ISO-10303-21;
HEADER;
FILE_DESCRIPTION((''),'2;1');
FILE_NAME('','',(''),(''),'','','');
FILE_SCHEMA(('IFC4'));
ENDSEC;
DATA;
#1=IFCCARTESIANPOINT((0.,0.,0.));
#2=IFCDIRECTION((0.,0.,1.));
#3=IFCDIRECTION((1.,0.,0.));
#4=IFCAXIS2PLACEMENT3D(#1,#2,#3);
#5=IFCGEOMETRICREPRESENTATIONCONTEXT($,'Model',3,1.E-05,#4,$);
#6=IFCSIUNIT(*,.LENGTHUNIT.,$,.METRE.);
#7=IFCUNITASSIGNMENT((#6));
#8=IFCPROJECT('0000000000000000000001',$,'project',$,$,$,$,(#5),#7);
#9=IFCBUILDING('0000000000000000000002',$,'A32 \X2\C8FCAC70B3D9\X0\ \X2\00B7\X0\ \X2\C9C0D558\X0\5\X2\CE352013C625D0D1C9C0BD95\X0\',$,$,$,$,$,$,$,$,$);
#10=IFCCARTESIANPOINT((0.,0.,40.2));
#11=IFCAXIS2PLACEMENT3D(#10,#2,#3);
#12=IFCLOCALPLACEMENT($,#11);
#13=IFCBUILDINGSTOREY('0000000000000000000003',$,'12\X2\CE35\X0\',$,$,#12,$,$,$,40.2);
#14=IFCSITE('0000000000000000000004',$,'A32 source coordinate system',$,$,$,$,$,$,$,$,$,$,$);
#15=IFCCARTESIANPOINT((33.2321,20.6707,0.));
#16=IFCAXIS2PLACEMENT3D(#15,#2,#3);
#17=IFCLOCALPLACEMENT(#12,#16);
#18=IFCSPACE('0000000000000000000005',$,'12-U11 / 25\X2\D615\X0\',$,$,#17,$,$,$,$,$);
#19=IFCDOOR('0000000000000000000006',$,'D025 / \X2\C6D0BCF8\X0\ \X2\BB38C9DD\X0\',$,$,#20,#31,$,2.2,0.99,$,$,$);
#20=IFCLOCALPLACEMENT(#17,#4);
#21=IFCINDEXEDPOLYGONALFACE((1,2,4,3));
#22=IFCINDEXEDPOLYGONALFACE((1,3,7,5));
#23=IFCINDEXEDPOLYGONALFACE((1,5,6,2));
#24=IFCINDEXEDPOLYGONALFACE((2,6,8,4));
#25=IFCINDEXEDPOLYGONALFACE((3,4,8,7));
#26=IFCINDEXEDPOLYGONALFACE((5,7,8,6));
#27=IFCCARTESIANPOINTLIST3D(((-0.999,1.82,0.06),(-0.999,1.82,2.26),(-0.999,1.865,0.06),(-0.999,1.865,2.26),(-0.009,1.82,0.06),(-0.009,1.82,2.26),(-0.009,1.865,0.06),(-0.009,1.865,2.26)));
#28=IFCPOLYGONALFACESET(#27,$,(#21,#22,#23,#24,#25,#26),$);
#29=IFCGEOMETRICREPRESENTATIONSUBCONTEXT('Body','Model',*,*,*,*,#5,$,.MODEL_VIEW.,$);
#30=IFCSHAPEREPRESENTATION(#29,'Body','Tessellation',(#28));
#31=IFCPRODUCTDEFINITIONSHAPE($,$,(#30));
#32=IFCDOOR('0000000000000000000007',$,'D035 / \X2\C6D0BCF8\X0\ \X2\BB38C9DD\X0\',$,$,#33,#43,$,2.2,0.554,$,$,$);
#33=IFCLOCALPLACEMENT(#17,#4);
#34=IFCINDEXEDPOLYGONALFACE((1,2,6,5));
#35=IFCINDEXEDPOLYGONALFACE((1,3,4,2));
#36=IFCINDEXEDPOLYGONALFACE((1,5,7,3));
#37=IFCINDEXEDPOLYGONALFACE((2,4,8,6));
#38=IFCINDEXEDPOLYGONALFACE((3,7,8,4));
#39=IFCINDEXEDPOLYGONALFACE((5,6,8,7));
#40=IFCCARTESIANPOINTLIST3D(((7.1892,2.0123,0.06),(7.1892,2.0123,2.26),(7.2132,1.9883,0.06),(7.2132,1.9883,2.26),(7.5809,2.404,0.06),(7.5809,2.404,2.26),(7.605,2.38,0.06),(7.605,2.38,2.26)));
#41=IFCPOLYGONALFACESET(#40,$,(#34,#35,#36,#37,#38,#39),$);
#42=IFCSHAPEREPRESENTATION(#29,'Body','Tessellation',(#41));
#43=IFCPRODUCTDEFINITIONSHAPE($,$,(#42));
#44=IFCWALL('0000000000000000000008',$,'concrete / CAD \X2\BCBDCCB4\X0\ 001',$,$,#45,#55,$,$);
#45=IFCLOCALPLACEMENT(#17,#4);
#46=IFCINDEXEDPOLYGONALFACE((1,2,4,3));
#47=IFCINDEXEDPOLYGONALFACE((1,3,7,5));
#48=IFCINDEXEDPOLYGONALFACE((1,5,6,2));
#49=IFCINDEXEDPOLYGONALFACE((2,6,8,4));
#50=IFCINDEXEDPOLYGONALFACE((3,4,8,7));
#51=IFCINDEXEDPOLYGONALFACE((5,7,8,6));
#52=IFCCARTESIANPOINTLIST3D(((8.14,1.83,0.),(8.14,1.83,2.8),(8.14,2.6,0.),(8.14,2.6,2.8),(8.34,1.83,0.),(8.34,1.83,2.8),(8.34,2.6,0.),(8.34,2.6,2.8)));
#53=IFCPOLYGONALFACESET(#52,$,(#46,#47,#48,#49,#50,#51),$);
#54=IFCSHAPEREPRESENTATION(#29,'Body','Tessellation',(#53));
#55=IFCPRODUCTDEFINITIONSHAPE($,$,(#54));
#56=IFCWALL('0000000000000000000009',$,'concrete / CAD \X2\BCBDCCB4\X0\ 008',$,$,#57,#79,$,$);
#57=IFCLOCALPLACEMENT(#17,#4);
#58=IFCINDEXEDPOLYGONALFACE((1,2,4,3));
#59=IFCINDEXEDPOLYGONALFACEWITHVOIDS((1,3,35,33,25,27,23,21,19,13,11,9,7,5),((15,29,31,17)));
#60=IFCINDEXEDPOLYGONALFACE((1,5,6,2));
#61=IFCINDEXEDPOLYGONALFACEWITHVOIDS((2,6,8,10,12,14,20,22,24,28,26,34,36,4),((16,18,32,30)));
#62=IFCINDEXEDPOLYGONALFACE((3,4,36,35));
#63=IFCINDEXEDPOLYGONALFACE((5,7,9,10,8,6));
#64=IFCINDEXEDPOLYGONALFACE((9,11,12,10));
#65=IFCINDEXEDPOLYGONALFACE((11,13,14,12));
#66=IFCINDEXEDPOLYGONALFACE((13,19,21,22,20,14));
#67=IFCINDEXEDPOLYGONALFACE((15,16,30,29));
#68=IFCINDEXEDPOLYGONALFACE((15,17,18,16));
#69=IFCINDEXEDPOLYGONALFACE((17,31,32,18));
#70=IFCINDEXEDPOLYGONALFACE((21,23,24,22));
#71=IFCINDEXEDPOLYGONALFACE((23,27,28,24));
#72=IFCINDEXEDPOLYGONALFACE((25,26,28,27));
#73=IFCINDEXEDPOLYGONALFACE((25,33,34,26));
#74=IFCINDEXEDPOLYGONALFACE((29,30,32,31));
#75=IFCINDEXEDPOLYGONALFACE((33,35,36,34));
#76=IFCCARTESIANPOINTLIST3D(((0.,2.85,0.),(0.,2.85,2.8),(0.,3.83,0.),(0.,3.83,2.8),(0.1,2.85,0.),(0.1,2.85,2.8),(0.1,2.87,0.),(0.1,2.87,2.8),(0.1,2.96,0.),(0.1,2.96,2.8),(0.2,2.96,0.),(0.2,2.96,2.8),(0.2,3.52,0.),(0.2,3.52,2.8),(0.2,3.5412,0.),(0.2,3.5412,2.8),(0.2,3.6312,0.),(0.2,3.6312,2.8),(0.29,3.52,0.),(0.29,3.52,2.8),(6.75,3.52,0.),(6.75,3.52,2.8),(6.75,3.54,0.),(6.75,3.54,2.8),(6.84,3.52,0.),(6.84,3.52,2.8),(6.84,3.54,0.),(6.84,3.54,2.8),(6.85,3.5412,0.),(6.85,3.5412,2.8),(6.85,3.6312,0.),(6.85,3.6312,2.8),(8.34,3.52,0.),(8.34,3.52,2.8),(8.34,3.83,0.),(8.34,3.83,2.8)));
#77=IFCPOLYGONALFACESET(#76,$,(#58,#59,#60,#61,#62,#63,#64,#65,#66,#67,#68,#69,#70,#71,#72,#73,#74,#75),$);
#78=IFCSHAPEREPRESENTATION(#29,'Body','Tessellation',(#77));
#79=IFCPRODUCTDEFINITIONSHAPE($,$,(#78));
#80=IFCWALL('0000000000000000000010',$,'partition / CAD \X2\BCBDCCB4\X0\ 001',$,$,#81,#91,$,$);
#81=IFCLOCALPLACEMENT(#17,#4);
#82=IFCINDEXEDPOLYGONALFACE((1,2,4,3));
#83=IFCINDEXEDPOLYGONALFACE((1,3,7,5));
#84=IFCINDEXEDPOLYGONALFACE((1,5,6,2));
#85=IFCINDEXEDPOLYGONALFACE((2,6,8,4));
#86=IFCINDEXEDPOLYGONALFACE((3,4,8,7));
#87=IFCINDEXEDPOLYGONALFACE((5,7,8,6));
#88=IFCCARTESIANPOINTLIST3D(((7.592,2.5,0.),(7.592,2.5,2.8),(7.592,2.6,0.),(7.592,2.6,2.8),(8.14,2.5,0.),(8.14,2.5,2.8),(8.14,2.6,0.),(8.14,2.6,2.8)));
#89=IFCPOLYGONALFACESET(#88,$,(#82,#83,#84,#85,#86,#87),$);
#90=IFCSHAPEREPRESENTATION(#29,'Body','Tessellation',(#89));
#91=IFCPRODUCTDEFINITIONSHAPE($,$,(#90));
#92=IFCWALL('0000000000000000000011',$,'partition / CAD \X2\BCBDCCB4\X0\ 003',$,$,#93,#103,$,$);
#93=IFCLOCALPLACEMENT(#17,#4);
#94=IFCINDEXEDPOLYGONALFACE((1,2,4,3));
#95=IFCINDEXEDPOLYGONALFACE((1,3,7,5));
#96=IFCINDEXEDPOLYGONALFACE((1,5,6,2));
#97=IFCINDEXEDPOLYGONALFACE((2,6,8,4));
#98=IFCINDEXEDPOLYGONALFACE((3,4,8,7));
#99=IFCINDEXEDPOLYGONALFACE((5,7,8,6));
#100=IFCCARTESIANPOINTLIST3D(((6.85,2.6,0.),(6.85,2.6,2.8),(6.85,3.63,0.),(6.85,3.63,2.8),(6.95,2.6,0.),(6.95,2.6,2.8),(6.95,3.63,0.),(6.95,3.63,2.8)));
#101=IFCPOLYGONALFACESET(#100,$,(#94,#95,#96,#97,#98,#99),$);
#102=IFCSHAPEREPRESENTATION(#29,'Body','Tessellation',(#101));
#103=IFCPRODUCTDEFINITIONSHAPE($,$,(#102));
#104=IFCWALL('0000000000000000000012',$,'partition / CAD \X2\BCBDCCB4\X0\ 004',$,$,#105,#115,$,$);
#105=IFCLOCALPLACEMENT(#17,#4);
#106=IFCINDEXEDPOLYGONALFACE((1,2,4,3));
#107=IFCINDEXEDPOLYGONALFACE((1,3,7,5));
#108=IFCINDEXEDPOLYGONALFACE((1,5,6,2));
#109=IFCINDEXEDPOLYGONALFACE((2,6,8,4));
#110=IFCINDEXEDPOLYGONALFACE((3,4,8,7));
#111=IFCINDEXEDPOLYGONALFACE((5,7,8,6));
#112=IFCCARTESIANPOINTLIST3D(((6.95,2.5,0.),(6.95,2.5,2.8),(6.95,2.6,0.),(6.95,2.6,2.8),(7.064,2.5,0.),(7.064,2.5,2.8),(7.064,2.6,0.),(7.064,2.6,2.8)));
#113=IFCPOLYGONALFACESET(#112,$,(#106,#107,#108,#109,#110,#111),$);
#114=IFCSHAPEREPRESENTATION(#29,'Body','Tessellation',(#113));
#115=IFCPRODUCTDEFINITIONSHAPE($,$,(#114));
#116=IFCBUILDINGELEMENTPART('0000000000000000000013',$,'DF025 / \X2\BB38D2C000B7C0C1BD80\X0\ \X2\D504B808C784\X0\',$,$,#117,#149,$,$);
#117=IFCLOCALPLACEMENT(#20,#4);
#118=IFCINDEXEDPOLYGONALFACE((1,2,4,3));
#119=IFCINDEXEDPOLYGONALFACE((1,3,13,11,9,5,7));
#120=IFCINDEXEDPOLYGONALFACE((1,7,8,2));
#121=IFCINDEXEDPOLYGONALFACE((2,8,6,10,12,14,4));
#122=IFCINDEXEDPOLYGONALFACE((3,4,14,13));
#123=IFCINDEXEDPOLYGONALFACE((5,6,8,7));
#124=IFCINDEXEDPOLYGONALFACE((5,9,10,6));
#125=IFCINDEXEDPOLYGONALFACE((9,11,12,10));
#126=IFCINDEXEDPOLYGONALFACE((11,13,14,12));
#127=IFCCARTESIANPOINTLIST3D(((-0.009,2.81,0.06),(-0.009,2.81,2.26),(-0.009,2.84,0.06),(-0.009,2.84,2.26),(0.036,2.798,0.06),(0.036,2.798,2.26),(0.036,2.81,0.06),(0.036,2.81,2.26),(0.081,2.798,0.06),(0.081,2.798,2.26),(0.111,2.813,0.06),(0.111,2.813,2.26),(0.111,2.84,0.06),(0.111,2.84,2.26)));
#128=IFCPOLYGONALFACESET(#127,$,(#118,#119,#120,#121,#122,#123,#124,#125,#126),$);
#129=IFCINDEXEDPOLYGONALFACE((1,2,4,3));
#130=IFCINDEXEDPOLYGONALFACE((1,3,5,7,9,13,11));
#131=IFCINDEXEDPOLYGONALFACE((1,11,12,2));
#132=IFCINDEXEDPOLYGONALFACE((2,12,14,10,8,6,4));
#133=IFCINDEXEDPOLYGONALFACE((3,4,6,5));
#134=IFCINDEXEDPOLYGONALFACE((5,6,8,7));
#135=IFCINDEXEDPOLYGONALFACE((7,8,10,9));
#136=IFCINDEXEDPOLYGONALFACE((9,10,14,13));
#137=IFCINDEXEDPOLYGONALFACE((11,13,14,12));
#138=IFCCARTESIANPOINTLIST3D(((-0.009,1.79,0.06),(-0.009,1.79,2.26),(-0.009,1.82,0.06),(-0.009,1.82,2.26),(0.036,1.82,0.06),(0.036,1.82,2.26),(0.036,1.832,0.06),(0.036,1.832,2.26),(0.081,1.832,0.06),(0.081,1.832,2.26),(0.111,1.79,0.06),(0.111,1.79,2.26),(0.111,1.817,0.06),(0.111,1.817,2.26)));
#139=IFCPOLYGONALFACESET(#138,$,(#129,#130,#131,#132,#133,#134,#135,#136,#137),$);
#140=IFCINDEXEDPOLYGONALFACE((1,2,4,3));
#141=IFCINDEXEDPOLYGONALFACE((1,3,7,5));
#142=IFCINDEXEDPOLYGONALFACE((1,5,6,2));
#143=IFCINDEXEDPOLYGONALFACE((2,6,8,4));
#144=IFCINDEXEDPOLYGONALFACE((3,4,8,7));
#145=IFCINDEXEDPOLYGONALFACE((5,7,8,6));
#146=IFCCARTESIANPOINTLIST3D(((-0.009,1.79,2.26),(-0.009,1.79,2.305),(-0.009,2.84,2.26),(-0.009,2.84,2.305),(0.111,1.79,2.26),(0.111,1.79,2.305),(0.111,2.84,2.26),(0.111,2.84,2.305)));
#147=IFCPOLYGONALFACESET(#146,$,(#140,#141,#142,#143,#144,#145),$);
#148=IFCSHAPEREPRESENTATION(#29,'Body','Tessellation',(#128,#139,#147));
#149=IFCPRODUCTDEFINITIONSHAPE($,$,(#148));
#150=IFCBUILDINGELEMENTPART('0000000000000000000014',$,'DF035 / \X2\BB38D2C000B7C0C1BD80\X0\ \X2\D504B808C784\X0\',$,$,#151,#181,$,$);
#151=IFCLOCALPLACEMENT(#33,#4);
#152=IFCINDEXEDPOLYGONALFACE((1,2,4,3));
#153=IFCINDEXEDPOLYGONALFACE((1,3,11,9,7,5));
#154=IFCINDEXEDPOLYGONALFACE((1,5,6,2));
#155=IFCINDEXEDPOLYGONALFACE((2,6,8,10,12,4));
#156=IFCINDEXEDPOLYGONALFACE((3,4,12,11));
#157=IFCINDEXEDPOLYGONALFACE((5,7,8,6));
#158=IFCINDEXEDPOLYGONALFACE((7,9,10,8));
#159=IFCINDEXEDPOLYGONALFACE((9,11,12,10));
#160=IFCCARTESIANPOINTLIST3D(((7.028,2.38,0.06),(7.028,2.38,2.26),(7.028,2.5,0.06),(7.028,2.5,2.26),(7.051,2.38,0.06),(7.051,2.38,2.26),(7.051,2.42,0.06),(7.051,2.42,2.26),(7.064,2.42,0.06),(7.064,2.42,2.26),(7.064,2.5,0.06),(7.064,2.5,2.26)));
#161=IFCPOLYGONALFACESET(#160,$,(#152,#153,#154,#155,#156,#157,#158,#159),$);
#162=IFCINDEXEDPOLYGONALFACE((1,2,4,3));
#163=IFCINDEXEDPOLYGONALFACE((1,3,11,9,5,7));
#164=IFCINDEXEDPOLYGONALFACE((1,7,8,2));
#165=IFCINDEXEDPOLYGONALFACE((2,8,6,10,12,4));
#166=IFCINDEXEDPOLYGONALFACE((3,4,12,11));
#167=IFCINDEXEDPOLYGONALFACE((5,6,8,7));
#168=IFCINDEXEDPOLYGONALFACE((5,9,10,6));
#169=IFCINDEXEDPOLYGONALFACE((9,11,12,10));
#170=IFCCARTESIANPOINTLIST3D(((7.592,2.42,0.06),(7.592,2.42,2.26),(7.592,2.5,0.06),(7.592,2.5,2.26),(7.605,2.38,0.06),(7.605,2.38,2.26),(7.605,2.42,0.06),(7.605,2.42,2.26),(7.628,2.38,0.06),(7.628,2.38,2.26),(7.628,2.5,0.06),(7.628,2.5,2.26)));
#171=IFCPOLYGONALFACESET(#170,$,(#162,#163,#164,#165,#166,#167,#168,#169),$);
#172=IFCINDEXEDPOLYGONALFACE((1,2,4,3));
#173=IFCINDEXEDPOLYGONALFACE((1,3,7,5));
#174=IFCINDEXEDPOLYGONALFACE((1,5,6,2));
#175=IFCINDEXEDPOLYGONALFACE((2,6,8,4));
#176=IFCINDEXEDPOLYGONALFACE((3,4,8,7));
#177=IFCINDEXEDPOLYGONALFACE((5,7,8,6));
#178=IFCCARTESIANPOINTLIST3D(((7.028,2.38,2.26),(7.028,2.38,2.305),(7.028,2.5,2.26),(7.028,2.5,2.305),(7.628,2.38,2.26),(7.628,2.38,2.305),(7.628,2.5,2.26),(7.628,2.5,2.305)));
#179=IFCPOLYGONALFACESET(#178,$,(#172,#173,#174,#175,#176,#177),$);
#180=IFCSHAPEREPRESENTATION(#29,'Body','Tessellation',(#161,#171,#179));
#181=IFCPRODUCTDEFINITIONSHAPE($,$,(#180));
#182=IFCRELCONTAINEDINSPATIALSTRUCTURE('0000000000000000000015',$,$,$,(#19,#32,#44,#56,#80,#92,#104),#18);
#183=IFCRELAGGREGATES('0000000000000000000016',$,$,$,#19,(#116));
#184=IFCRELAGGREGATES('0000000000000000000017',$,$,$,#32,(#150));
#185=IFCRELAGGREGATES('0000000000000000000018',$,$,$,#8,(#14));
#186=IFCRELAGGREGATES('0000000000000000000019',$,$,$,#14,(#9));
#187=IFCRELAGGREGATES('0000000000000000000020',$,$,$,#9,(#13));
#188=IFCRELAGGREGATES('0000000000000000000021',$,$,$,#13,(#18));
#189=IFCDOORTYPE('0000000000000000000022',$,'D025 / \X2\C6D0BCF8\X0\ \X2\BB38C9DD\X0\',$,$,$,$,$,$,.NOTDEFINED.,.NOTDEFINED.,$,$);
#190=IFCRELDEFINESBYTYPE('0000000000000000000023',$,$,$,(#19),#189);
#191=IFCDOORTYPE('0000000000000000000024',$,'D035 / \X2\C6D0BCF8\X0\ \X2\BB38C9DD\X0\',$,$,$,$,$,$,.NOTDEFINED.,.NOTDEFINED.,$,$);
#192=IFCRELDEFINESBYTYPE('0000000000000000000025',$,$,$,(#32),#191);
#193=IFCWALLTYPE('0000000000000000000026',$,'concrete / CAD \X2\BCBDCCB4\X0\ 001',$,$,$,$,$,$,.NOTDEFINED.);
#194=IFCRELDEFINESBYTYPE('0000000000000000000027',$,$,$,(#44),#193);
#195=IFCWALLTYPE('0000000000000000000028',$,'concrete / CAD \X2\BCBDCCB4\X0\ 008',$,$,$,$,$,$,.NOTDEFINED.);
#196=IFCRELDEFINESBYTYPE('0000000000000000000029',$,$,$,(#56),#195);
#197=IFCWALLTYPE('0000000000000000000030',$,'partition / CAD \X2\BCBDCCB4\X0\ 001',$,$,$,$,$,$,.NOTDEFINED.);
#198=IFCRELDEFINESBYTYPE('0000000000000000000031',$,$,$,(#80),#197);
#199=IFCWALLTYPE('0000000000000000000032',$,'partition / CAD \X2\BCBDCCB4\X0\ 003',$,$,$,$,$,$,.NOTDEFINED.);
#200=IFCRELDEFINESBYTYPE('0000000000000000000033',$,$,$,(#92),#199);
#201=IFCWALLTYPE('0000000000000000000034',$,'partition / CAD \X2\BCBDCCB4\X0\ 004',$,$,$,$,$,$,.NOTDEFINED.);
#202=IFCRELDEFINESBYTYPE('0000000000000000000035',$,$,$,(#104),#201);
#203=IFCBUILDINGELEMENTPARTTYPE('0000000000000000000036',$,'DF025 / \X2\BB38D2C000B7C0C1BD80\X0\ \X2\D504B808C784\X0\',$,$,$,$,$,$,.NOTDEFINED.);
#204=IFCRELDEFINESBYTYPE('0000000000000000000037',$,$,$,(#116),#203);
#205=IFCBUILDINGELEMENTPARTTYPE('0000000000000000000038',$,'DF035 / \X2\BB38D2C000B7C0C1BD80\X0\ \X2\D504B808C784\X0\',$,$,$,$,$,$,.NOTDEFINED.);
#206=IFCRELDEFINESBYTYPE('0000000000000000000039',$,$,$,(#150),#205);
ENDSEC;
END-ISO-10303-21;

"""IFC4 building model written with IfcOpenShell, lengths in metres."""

from ifc_helpers import new_model, si_unit, frame, origin, origin_with_axes, place, context, subcontext, project, spatial, polyline, outline, extrude, source, transform, mapped, type_object, type_shapes, element, aggregate, save


model = new_model("IFC4")

# Units and contexts
model_context = context("Model", 3, precision=1e-05, world=origin_with_axes())
body_context = subcontext(model_context, "Body", "Model", "MODEL_VIEW")
ifc_project = project(units=[si_unit("LENGTHUNIT", "METRE")], contexts=[model_context])

# Site, building, storey, space
storey_placement = place(None, frame((0.0, 0.0, 40.2), z_axis=(0.0, 0.0, 1.0), x_axis=(1.0, 0.0, 0.0)))
space_placement = place(storey_placement, frame((33.2321, 20.6707, 0.0), z_axis=(0.0, 0.0, 1.0), x_axis=(1.0, 0.0, 0.0)))
site = spatial("IfcSite", under=ifc_project, Name="A32 source coordinate system")
building = spatial("IfcBuilding", under=site, Name="A32 주거동 · 지하5층–옥탑지붕")
storey = spatial("IfcBuildingStorey", under=building, at=storey_placement, Name="12층", Elevation=40.2)
space = spatial("IfcSpace", under=storey, at=space_placement, Name="12-U11 / 25형")

# Doors
door_type_1 = type_object("IfcDoorType", Name="D025 / 원본 문짝", OperationType="NOTDEFINED", PredefinedType="NOTDEFINED")
shared_shape_1 = source(origin(), body_context, "Body", "SweptSolid", [
    extrude(outline(polyline([(-0.009, 1.82), (-0.999, 1.82), (-0.999, 1.865), (-0.009, 1.865), (-0.009, 1.82)])), frame((0.0, 0.0, 0.06)), (0.0, 0.0, 1.0), 2.2),
])
type_shapes(door_type_1, [shared_shape_1])
door_1_placement = place(space_placement, origin_with_axes())
door_1 = element("IfcDoor", 1, at=door_1_placement, inside=space, type_object=door_type_1, Name="D025 / 원본 문짝", OverallHeight=2.2, OverallWidth=0.99, context=body_context, shape_type="MappedRepresentation", body=[
    mapped(shared_shape_1, transform((0.0, 0.0, 0.0), scale=1.0)),
])
door_type_2 = type_object("IfcDoorType", Name="D035 / 원본 문짝", OperationType="NOTDEFINED", PredefinedType="NOTDEFINED")
shared_shape_2 = source(origin(), body_context, "Body", "SweptSolid", [
    extrude(outline(polyline([(7.605, 2.38), (7.2132, 1.9883), (7.1892, 2.0123), (7.5809, 2.404), (7.605, 2.38)])), frame((0.0, 0.0, 0.06)), (0.0, 0.0, 1.0), 2.2),
])
type_shapes(door_type_2, [shared_shape_2])
door_2_placement = place(space_placement, origin_with_axes())
door_2 = element("IfcDoor", 2, at=door_2_placement, inside=space, type_object=door_type_2, Name="D035 / 원본 문짝", OverallHeight=2.2, OverallWidth=0.554, context=body_context, shape_type="MappedRepresentation", body=[
    mapped(shared_shape_2, transform((0.0, 0.0, 0.0), scale=1.0)),
])

# Walls
wall_type_1 = type_object("IfcWallType", Name="concrete / CAD 벽체 001", PredefinedType="NOTDEFINED")
shared_shape_3 = source(origin(), body_context, "Body", "SweptSolid", [
    extrude(outline(polyline([(8.34, 1.83), (8.14, 1.83), (8.14, 2.6), (8.34, 2.6), (8.34, 1.83)])), origin(), (0.0, 0.0, 1.0), 2.8),
])
type_shapes(wall_type_1, [shared_shape_3])
wall_1_placement = place(space_placement, origin_with_axes())
element("IfcWall", 3, at=wall_1_placement, inside=space, type_object=wall_type_1, Name="concrete / CAD 벽체 001", context=body_context, shape_type="MappedRepresentation", body=[
    mapped(shared_shape_3, transform((0.0, 0.0, 0.0), scale=1.0)),
])
wall_type_2 = type_object("IfcWallType", Name="concrete / CAD 벽체 008", PredefinedType="NOTDEFINED")
shared_shape_4 = source(origin(), body_context, "Body", "SweptSolid", [
    extrude(outline(polyline([(0.0, 3.83), (8.34, 3.83), (8.34, 3.52), (6.84, 3.52), (6.84, 3.54), (6.75, 3.54), (6.75, 3.52), (0.29, 3.52), (0.2, 3.52), (0.2, 2.96), (0.1, 2.96), (0.1, 2.87), (0.1, 2.85), (0.0, 2.85), (0.0, 3.83)]), holes=[polyline([(6.85, 3.5412), (6.85, 3.6312), (0.2, 3.6312), (0.2, 3.5412), (6.85, 3.5412)])]), origin(), (0.0, 0.0, 1.0), 2.8),
])
type_shapes(wall_type_2, [shared_shape_4])
wall_2_placement = place(space_placement, origin_with_axes())
element("IfcWall", 4, at=wall_2_placement, inside=space, type_object=wall_type_2, Name="concrete / CAD 벽체 008", context=body_context, shape_type="MappedRepresentation", body=[
    mapped(shared_shape_4, transform((0.0, 0.0, 0.0), scale=1.0)),
])
wall_type_3 = type_object("IfcWallType", Name="partition / CAD 벽체 001", PredefinedType="NOTDEFINED")
shared_shape_5 = source(origin(), body_context, "Body", "SweptSolid", [
    extrude(outline(polyline([(8.14, 2.6), (8.14, 2.5), (7.592, 2.5), (7.592, 2.6), (8.14, 2.6)])), origin(), (0.0, 0.0, 1.0), 2.8),
])
type_shapes(wall_type_3, [shared_shape_5])
wall_3_placement = place(space_placement, origin_with_axes())
element("IfcWall", 5, at=wall_3_placement, inside=space, type_object=wall_type_3, Name="partition / CAD 벽체 001", context=body_context, shape_type="MappedRepresentation", body=[
    mapped(shared_shape_5, transform((0.0, 0.0, 0.0), scale=1.0)),
])
wall_type_4 = type_object("IfcWallType", Name="partition / CAD 벽체 003", PredefinedType="NOTDEFINED")
shared_shape_6 = source(origin(), body_context, "Body", "SweptSolid", [
    extrude(outline(polyline([(6.85, 2.6), (6.85, 3.63), (6.95, 3.63), (6.95, 2.6), (6.85, 2.6)])), origin(), (0.0, 0.0, 1.0), 2.8),
])
type_shapes(wall_type_4, [shared_shape_6])
wall_4_placement = place(space_placement, origin_with_axes())
element("IfcWall", 6, at=wall_4_placement, inside=space, type_object=wall_type_4, Name="partition / CAD 벽체 003", context=body_context, shape_type="MappedRepresentation", body=[
    mapped(shared_shape_6, transform((0.0, 0.0, 0.0), scale=1.0)),
])
wall_type_5 = type_object("IfcWallType", Name="partition / CAD 벽체 004", PredefinedType="NOTDEFINED")
shared_shape_7 = source(origin(), body_context, "Body", "SweptSolid", [
    extrude(outline(polyline([(6.95, 2.5), (6.95, 2.6), (7.064, 2.6), (7.064, 2.5), (6.95, 2.5)])), origin(), (0.0, 0.0, 1.0), 2.8),
])
type_shapes(wall_type_5, [shared_shape_7])
wall_5_placement = place(space_placement, origin_with_axes())
element("IfcWall", 7, at=wall_5_placement, inside=space, type_object=wall_type_5, Name="partition / CAD 벽체 004", context=body_context, shape_type="MappedRepresentation", body=[
    mapped(shared_shape_7, transform((0.0, 0.0, 0.0), scale=1.0)),
])

# Building element parts
building_element_part_type_1 = type_object("IfcBuildingElementPartType", Name="DF025 / 문틀·상부 프레임", PredefinedType="NOTDEFINED")
shared_shape_8 = source(origin(), body_context, "Body", "SweptSolid", [
    extrude(outline(polyline([(0.111, 2.84), (0.111, 2.813), (0.081, 2.798), (0.036, 2.798), (0.036, 2.81), (-0.009, 2.81), (-0.009, 2.84), (0.111, 2.84)])), frame((0.0, 0.0, 0.06)), (0.0, 0.0, 1.0), 2.2),
    extrude(outline(polyline([(-0.009, 1.82), (0.036, 1.82), (0.036, 1.832), (0.081, 1.832), (0.111, 1.817), (0.111, 1.79), (-0.009, 1.79), (-0.009, 1.82)])), frame((0.0, 0.0, 0.06)), (0.0, 0.0, 1.0), 2.2),
    extrude(outline(polyline([(-0.009, 1.79), (-0.009, 2.84), (0.111, 2.84), (0.111, 1.79), (-0.009, 1.79)])), frame((0.0, 0.0, 2.26)), (0.0, 0.0, 1.0), 0.045),
])
type_shapes(building_element_part_type_1, [shared_shape_8])
building_element_part_1_placement = place(door_1_placement, origin_with_axes())
building_element_part_1 = element("IfcBuildingElementPart", 8, at=building_element_part_1_placement, type_object=building_element_part_type_1, Name="DF025 / 문틀·상부 프레임", context=body_context, shape_type="MappedRepresentation", body=[
    mapped(shared_shape_8, transform((0.0, 0.0, 0.0), scale=1.0)),
])
aggregate(door_1, [building_element_part_1])
building_element_part_type_2 = type_object("IfcBuildingElementPartType", Name="DF035 / 문틀·상부 프레임", PredefinedType="NOTDEFINED")
shared_shape_9 = source(origin(), body_context, "Body", "SweptSolid", [
    extrude(outline(polyline([(7.064, 2.5), (7.064, 2.42), (7.051, 2.42), (7.051, 2.38), (7.028, 2.38), (7.028, 2.5), (7.064, 2.5)])), frame((0.0, 0.0, 0.06)), (0.0, 0.0, 1.0), 2.2),
    extrude(outline(polyline([(7.628, 2.38), (7.605, 2.38), (7.605, 2.42), (7.592, 2.42), (7.592, 2.5), (7.628, 2.5), (7.628, 2.38)])), frame((0.0, 0.0, 0.06)), (0.0, 0.0, 1.0), 2.2),
    extrude(outline(polyline([(7.028, 2.38), (7.028, 2.5), (7.628, 2.5), (7.628, 2.38), (7.028, 2.38)])), frame((0.0, 0.0, 2.26)), (0.0, 0.0, 1.0), 0.045),
])
type_shapes(building_element_part_type_2, [shared_shape_9])
building_element_part_2_placement = place(door_2_placement, origin_with_axes())
building_element_part_2 = element("IfcBuildingElementPart", 9, at=building_element_part_2_placement, type_object=building_element_part_type_2, Name="DF035 / 문틀·상부 프레임", context=body_context, shape_type="MappedRepresentation", body=[
    mapped(shared_shape_9, transform((0.0, 0.0, 0.0), scale=1.0)),
])
aggregate(door_2, [building_element_part_2])

save(model, "model.ifc")
